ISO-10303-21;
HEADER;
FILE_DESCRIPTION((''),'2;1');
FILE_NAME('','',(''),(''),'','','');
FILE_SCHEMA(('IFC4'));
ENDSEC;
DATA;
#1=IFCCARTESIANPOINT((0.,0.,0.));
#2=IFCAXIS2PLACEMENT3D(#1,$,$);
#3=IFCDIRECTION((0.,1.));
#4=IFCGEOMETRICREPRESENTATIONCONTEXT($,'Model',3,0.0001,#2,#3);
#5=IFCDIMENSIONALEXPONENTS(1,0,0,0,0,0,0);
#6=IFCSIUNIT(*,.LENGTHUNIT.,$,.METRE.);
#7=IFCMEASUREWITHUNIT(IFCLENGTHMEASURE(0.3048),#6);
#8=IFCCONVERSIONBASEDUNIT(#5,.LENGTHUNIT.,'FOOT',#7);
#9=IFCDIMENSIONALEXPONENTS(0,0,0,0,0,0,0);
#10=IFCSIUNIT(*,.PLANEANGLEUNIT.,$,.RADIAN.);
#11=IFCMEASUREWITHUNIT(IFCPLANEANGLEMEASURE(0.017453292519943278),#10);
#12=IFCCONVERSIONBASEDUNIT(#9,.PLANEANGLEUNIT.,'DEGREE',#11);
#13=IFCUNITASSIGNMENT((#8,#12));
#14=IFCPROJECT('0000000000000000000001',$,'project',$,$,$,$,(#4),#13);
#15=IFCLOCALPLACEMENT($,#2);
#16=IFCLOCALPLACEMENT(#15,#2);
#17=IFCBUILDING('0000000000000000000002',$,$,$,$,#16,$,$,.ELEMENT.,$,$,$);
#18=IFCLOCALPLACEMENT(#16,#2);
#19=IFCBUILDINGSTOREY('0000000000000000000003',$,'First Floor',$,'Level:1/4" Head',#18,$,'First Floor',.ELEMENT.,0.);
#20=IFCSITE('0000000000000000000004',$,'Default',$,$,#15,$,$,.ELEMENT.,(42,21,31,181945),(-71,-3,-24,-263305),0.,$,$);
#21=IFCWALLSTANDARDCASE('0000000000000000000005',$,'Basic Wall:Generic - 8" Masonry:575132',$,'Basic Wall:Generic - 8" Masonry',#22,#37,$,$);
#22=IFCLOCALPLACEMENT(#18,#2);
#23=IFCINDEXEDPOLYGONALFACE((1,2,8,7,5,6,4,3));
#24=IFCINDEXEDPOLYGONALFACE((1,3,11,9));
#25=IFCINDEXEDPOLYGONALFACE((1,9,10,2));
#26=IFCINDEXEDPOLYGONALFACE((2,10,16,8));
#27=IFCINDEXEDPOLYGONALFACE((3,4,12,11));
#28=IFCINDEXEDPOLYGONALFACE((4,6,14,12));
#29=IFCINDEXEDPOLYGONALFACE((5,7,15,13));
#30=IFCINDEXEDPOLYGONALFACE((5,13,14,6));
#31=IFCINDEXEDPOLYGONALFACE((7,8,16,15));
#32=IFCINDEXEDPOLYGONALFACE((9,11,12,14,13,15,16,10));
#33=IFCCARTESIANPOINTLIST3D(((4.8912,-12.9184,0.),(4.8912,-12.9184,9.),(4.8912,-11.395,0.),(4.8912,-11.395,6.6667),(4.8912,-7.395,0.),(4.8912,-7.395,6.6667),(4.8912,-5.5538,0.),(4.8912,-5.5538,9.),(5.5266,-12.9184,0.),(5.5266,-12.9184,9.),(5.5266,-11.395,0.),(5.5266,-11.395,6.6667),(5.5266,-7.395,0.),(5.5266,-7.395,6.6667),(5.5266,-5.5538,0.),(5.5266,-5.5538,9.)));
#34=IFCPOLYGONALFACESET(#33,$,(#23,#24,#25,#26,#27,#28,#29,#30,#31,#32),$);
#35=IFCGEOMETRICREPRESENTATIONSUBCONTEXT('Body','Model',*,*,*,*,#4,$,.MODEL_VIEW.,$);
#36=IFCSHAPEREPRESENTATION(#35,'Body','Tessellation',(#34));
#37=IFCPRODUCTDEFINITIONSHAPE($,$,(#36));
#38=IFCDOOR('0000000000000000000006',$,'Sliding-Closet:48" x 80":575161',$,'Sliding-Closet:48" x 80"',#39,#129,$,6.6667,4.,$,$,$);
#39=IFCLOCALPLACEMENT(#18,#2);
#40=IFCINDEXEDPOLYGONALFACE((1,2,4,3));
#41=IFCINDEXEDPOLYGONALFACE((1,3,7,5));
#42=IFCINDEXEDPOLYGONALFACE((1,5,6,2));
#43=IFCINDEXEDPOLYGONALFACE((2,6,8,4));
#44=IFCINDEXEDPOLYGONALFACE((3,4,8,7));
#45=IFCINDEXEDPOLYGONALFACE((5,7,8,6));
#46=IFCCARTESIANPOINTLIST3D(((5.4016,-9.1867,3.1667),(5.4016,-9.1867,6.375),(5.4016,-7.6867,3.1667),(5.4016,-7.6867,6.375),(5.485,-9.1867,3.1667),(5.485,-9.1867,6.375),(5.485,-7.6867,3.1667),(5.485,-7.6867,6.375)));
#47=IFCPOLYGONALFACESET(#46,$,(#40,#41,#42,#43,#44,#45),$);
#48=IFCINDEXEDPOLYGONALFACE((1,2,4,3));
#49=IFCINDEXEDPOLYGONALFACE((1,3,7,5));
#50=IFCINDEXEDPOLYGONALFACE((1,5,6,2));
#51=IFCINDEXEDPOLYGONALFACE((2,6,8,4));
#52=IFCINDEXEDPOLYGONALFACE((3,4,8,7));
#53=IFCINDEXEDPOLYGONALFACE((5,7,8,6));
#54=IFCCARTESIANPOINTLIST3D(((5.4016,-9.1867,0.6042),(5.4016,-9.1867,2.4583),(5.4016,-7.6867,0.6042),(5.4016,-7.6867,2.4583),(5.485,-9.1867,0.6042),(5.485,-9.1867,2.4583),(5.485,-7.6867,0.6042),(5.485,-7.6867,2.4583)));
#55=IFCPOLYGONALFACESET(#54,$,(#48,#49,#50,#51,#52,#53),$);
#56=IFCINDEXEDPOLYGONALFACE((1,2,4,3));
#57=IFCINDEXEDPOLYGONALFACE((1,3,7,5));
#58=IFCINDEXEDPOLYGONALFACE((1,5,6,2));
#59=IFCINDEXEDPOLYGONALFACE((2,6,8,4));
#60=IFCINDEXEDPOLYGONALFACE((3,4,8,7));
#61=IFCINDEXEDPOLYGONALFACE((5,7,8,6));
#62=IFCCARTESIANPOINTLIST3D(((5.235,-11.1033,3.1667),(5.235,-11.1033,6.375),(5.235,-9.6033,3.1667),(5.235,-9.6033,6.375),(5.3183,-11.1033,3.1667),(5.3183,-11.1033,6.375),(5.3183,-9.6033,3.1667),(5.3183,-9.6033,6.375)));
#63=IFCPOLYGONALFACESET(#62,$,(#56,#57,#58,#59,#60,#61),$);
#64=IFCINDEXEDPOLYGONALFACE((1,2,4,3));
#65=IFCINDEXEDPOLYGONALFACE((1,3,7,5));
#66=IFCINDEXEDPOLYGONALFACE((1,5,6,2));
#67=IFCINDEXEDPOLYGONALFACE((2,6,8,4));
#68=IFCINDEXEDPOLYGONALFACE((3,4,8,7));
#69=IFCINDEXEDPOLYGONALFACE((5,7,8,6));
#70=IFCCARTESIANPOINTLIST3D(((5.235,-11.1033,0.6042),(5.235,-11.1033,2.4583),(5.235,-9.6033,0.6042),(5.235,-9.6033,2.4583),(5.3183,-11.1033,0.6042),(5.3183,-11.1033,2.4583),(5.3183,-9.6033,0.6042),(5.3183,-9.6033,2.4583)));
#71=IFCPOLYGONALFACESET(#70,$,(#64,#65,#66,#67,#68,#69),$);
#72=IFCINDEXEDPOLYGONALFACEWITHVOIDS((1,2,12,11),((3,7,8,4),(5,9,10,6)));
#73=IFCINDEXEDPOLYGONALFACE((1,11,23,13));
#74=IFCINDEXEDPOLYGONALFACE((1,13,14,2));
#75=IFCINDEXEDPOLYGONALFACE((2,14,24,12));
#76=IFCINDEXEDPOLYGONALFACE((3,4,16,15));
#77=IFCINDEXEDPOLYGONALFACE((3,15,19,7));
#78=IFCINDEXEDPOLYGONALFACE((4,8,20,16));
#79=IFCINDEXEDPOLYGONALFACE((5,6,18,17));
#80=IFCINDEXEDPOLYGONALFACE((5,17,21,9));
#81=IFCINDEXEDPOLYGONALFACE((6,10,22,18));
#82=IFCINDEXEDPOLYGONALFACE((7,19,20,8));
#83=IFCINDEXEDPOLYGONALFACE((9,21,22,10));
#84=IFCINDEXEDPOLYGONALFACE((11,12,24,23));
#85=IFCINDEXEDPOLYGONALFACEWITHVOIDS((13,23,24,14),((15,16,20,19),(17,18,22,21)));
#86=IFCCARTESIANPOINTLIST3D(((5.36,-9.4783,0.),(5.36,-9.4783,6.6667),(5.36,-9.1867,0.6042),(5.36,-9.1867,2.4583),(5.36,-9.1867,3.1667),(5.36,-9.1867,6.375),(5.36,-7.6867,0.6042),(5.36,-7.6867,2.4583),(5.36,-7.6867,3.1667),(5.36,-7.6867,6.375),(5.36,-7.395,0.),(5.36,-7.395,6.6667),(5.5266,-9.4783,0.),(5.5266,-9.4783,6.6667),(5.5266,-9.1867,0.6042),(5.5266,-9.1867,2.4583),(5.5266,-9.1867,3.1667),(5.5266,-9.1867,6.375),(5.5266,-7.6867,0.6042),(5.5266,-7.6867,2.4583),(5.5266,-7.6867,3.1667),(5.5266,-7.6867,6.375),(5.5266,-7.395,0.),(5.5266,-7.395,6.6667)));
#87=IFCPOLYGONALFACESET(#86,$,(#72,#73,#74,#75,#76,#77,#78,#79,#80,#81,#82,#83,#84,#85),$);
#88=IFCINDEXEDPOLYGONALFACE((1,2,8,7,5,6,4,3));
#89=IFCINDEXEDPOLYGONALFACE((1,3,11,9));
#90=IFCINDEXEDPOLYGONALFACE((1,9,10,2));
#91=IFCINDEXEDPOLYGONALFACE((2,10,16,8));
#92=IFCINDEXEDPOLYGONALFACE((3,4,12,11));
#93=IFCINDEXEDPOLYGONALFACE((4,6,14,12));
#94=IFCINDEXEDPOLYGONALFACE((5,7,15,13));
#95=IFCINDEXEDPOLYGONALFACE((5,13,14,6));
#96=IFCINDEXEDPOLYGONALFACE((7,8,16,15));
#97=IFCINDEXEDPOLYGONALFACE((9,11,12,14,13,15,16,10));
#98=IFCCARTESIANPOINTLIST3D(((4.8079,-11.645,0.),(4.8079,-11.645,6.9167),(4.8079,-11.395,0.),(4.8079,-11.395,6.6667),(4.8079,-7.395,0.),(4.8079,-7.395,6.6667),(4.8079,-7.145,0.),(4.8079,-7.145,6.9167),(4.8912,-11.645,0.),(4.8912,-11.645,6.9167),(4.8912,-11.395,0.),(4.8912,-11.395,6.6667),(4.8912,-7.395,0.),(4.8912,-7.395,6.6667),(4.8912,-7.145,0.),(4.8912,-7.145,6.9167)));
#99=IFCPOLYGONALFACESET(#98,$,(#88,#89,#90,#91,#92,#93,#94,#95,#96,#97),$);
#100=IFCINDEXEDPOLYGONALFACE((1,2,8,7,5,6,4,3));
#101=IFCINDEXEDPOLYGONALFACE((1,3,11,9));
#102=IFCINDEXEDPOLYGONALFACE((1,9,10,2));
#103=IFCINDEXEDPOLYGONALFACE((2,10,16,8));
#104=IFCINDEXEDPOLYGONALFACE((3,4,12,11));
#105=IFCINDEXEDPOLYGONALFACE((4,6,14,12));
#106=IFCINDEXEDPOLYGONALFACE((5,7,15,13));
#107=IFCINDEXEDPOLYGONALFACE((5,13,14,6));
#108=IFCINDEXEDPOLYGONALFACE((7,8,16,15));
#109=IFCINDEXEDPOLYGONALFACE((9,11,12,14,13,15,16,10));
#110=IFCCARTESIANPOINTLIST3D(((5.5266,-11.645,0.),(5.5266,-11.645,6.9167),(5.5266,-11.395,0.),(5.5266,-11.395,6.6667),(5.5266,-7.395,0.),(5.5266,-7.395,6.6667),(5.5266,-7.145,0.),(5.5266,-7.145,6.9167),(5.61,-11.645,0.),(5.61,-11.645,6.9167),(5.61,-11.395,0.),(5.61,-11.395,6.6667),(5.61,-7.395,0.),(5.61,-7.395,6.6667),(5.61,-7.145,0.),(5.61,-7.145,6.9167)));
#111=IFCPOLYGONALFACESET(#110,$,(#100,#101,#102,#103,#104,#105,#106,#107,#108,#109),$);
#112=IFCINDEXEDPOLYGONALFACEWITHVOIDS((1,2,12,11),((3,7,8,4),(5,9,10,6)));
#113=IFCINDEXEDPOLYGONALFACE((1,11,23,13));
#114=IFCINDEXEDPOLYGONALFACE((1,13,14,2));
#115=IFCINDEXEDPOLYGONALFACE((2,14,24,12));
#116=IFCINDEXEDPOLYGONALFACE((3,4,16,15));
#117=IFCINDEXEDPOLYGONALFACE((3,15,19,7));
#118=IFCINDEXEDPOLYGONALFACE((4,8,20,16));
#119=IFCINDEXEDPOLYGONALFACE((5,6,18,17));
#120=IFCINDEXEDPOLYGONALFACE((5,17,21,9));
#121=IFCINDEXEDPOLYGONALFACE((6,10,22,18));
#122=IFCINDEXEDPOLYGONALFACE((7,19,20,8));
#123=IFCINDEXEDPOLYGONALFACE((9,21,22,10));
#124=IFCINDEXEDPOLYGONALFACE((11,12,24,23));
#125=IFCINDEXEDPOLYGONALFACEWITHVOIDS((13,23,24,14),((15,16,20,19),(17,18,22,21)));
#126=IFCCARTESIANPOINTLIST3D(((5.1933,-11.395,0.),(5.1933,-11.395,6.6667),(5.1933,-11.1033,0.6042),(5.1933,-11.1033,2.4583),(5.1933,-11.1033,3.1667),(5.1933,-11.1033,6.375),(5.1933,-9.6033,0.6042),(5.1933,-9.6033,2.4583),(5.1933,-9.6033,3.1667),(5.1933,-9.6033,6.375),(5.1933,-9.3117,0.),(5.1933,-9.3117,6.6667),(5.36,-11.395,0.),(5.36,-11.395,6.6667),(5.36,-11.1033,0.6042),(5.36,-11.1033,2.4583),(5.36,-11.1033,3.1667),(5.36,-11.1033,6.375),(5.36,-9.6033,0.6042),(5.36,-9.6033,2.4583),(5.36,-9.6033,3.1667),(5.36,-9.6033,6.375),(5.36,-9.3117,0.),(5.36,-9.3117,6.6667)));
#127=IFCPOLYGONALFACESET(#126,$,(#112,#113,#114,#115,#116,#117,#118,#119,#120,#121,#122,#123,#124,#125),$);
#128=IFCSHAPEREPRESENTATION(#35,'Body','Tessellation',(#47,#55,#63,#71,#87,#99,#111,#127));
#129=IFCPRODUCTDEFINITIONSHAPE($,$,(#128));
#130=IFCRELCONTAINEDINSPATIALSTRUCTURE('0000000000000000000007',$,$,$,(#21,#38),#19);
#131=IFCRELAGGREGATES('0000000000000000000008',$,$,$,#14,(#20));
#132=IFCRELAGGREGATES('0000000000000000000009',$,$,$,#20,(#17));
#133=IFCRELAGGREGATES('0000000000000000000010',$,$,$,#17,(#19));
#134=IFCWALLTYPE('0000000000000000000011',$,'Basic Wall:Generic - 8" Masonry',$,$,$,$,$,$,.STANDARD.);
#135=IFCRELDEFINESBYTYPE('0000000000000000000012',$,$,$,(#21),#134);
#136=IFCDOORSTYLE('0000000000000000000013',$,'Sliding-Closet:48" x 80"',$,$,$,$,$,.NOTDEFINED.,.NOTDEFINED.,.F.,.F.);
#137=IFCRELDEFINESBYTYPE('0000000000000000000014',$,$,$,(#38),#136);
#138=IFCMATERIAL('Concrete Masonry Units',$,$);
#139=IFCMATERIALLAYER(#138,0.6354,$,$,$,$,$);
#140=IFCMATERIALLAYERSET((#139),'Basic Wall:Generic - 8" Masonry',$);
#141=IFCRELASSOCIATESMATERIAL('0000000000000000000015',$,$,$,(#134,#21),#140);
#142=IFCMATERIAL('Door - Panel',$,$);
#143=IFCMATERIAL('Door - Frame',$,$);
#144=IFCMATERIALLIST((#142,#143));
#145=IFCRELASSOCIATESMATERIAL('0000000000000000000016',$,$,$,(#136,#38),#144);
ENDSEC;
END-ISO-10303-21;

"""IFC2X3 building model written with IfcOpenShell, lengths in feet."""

from ifc_helpers import new_model, entity, si_unit, converted_unit, direction, frame, frame_2d, origin, origin_2d_with_axis, place, context, subcontext, project, spatial, polyline, rectangle, outline, extrude, source, transform, mapped, material, material_list, layer, layer_set, layer_usage, type_object, type_shapes, element, fill, save


model = new_model("IFC2X3")

# Units and contexts
model_context = context("Model", 3, precision=0.0001, world=origin(), true_north=direction((0.0, 1.0)))
body_context = subcontext(model_context, "Body", "Model", "MODEL_VIEW")
ifc_project = project(units=[converted_unit("LENGTHUNIT", "FOOT", entity("IfcLengthMeasure", 0.3048), si_unit("LENGTHUNIT", "METRE"), dimensions=[1, 0, 0, 0, 0, 0, 0]), converted_unit("PLANEANGLEUNIT", "DEGREE", entity("IfcPlaneAngleMeasure", 0.017453292519943278), si_unit("PLANEANGLEUNIT", "RADIAN"), dimensions=[0, 0, 0, 0, 0, 0, 0])], contexts=[model_context])

# Site, building, storey
site_placement = place(None, origin())
site = spatial("IfcSite", under=ifc_project, at=site_placement, Name="Default", CompositionType="ELEMENT", RefLatitude=(42, 21, 31, 181945), RefLongitude=(-71, -3, -24, -263305), RefElevation=0.0)
building_placement = place(site_placement, origin())
building = spatial("IfcBuilding", under=site, at=building_placement, CompositionType="ELEMENT")
storey_placement = place(building_placement, origin())
storey = spatial("IfcBuildingStorey", under=building, at=storey_placement, Name="First Floor", ObjectType="Level:1/4\" Head", LongName="First Floor", CompositionType="ELEMENT", Elevation=0.0)

# Shared definitions
ifc_material_1 = material(Name="Concrete Masonry Units")
ifc_layer = layer(ifc_material_1, 0.6354)
ifc_layer_set = layer_set([ifc_layer], Name="Basic Wall:Generic - 8\" Masonry")
wall_type = type_object("IfcWallType", Name="Basic Wall:Generic - 8\" Masonry", PredefinedType="STANDARD", material=ifc_layer_set)

# Shared definitions
ifc_material_2 = material(Name="Door - Panel")
ifc_material_3 = material(Name="Door - Frame")
ifc_material_list_1 = material_list([ifc_material_2, ifc_material_3])
door_style_1 = type_object("IfcDoorStyle", Name="Sliding-Closet:48\" x 80\"", ConstructionType="NOTDEFINED", OperationType="NOTDEFINED", ParameterTakesPrecedence=False, Sizeable=False, material=ifc_material_list_1)
shared_shape_1 = source(origin(), body_context, "Body", "SweptSolid", [
    extrude(rectangle(XDim=0.0833, YDim=1.5, at=origin_2d_with_axis()), frame((1.0417, 0.5521, 3.1667), z_axis=(0.0, 0.0, 1.0), x_axis=(0.0, 1.0, 0.0)), (0.0, 0.0, 1.0), 3.2083),
    extrude(rectangle(XDim=0.0833, YDim=1.5, at=origin_2d_with_axis()), frame((1.0417, 0.5521, 0.6042), z_axis=(0.0, 0.0, 1.0), x_axis=(0.0, 1.0, 0.0)), (0.0, 0.0, 1.0), 1.8542),
    extrude(rectangle(XDim=0.0833, YDim=1.5, at=frame_2d((0.0, 0.0), x_axis=(1.0, 0.0))), frame((2.9583, 0.3854, 3.1667), z_axis=(0.0, 0.0, 1.0), x_axis=(0.0, -1.0, 0.0)), (0.0, 0.0, 1.0), 3.2083),
    extrude(rectangle(XDim=0.0833, YDim=1.5, at=frame_2d((0.0, 0.0), x_axis=(1.0, 0.0))), frame((2.9583, 0.3854, 0.6042), z_axis=(0.0, 0.0, 1.0), x_axis=(0.0, -1.0, 0.0)), (0.0, 0.0, 1.0), 1.8542),
    extrude(outline(polyline([(-3.3333, -1.0417), (3.3333, -1.0417), (3.3333, 1.0417), (-3.3333, 1.0417), (-3.3333, -1.0417)]), holes=[polyline([(2.7292, 0.75), (2.7292, -0.75), (0.875, -0.75), (0.875, 0.75), (2.7292, 0.75)]), polyline([(0.1667, 0.75), (0.1667, -0.75), (-3.0417, -0.75), (-3.0417, 0.75), (0.1667, 0.75)])]), frame((1.0417, 0.4688, 3.3333), z_axis=(0.0, 1.0, 0.0), x_axis=(0.0, 0.0, -1.0)), (0.0, 0.0, 1.0), 0.1667),
    extrude(outline(polyline([(-3.3958, -2.25), (3.5208, -2.25), (3.5208, 2.25), (-3.3958, 2.25), (-3.3958, 2.0), (3.2708, 2.0), (3.2708, -2.0), (-3.3958, -2.0), (-3.3958, -2.25)])), frame((2.0, -0.0833, 3.3958), z_axis=(0.0, 1.0, 0.0), x_axis=(0.0, 0.0, 1.0)), (0.0, 0.0, 1.0), 0.0833),
    extrude(outline(polyline([(-2.25, -3.3958), (-2.0, -3.3958), (-2.0, 3.2708), (2.0, 3.2708), (2.0, -3.3958), (2.25, -3.3958), (2.25, 3.5208), (-2.25, 3.5208), (-2.25, -3.3958)])), frame((2.0, 0.6354, 3.3958), z_axis=(0.0, 1.0, 0.0), x_axis=(-1.0, 0.0, 0.0)), (0.0, 0.0, 1.0), 0.0833),
    extrude(outline(polyline([(-1.0417, -3.3333), (1.0417, -3.3333), (1.0417, 3.3333), (-1.0417, 3.3333), (-1.0417, -3.3333)]), holes=[polyline([(0.75, 0.1667), (0.75, -3.0417), (-0.75, -3.0417), (-0.75, 0.1667), (0.75, 0.1667)]), polyline([(0.75, 2.7292), (0.75, 0.875), (-0.75, 0.875), (-0.75, 2.7292), (0.75, 2.7292)])]), frame((2.9583, 0.3021, 3.3333), z_axis=(0.0, 1.0, 0.0), x_axis=(1.0, 0.0, 0.0)), (0.0, 0.0, 1.0), 0.1667),
])
type_shapes(door_style_1, [shared_shape_1])

# Wall, opening, door
ifc_layer_usage_1 = layer_usage(ifc_layer_set, "AXIS2", "NEGATIVE", 0.3177)
wall_1_placement = place(storey_placement, frame((5.2089, -12.9184, 0.0), z_axis=(0.0, 0.0, 1.0), x_axis=(0.0, 1.0, 0.0)))
wall_1 = element("IfcWallStandardCase", 1, at=wall_1_placement, inside=storey, type_object=wall_type, material=ifc_layer_usage_1, Name="Basic Wall:Generic - 8\" Masonry:575132", ObjectType="Basic Wall:Generic - 8\" Masonry", context=body_context, shape_type="SweptSolid", body=[
    extrude(rectangle(XDim=7.3646, YDim=0.6354, at=frame_2d((3.6823, 0.0), x_axis=(1.0, 0.0))), origin(), (0.0, 0.0, 1.0), 9.0),
])
opening_1_placement = place(wall_1_placement, frame((5.5234, 0.3177, 0.0)))
opening_1 = element("IfcOpeningElement", 2, at=opening_1_placement, cuts=wall_1, ObjectType="Opening", context=body_context, shape_type="SweptSolid", body=[
    extrude(rectangle(XDim=6.6667, YDim=4.0, at=frame_2d((3.3333, 2.0), x_axis=(-1.0, 0.0))), frame((0.0, 0.0, 0.0), z_axis=(0.0, -1.0, 0.0), x_axis=(0.0, 0.0, 1.0)), (0.0, 0.0, 1.0), 0.6354),
])
door_1_placement = place(opening_1_placement, frame((0.0, 0.0, 0.0), z_axis=(0.0, 0.0, 1.0), x_axis=(-1.0, 0.0, 0.0)))
door_1 = element("IfcDoor", 3, at=door_1_placement, inside=storey, type_object=door_style_1, material=ifc_material_list_1, Name="Sliding-Closet:48\" x 80\":575161", ObjectType="Sliding-Closet:48\" x 80\"", OverallHeight=6.6667, OverallWidth=4.0, context=body_context, shape_type="MappedRepresentation", body=[
    mapped(shared_shape_1, transform((0.0, 0.0, 0.0), scale=1.0)),
])
fill(opening_1, door_1)

save(model, "model.ifc")
